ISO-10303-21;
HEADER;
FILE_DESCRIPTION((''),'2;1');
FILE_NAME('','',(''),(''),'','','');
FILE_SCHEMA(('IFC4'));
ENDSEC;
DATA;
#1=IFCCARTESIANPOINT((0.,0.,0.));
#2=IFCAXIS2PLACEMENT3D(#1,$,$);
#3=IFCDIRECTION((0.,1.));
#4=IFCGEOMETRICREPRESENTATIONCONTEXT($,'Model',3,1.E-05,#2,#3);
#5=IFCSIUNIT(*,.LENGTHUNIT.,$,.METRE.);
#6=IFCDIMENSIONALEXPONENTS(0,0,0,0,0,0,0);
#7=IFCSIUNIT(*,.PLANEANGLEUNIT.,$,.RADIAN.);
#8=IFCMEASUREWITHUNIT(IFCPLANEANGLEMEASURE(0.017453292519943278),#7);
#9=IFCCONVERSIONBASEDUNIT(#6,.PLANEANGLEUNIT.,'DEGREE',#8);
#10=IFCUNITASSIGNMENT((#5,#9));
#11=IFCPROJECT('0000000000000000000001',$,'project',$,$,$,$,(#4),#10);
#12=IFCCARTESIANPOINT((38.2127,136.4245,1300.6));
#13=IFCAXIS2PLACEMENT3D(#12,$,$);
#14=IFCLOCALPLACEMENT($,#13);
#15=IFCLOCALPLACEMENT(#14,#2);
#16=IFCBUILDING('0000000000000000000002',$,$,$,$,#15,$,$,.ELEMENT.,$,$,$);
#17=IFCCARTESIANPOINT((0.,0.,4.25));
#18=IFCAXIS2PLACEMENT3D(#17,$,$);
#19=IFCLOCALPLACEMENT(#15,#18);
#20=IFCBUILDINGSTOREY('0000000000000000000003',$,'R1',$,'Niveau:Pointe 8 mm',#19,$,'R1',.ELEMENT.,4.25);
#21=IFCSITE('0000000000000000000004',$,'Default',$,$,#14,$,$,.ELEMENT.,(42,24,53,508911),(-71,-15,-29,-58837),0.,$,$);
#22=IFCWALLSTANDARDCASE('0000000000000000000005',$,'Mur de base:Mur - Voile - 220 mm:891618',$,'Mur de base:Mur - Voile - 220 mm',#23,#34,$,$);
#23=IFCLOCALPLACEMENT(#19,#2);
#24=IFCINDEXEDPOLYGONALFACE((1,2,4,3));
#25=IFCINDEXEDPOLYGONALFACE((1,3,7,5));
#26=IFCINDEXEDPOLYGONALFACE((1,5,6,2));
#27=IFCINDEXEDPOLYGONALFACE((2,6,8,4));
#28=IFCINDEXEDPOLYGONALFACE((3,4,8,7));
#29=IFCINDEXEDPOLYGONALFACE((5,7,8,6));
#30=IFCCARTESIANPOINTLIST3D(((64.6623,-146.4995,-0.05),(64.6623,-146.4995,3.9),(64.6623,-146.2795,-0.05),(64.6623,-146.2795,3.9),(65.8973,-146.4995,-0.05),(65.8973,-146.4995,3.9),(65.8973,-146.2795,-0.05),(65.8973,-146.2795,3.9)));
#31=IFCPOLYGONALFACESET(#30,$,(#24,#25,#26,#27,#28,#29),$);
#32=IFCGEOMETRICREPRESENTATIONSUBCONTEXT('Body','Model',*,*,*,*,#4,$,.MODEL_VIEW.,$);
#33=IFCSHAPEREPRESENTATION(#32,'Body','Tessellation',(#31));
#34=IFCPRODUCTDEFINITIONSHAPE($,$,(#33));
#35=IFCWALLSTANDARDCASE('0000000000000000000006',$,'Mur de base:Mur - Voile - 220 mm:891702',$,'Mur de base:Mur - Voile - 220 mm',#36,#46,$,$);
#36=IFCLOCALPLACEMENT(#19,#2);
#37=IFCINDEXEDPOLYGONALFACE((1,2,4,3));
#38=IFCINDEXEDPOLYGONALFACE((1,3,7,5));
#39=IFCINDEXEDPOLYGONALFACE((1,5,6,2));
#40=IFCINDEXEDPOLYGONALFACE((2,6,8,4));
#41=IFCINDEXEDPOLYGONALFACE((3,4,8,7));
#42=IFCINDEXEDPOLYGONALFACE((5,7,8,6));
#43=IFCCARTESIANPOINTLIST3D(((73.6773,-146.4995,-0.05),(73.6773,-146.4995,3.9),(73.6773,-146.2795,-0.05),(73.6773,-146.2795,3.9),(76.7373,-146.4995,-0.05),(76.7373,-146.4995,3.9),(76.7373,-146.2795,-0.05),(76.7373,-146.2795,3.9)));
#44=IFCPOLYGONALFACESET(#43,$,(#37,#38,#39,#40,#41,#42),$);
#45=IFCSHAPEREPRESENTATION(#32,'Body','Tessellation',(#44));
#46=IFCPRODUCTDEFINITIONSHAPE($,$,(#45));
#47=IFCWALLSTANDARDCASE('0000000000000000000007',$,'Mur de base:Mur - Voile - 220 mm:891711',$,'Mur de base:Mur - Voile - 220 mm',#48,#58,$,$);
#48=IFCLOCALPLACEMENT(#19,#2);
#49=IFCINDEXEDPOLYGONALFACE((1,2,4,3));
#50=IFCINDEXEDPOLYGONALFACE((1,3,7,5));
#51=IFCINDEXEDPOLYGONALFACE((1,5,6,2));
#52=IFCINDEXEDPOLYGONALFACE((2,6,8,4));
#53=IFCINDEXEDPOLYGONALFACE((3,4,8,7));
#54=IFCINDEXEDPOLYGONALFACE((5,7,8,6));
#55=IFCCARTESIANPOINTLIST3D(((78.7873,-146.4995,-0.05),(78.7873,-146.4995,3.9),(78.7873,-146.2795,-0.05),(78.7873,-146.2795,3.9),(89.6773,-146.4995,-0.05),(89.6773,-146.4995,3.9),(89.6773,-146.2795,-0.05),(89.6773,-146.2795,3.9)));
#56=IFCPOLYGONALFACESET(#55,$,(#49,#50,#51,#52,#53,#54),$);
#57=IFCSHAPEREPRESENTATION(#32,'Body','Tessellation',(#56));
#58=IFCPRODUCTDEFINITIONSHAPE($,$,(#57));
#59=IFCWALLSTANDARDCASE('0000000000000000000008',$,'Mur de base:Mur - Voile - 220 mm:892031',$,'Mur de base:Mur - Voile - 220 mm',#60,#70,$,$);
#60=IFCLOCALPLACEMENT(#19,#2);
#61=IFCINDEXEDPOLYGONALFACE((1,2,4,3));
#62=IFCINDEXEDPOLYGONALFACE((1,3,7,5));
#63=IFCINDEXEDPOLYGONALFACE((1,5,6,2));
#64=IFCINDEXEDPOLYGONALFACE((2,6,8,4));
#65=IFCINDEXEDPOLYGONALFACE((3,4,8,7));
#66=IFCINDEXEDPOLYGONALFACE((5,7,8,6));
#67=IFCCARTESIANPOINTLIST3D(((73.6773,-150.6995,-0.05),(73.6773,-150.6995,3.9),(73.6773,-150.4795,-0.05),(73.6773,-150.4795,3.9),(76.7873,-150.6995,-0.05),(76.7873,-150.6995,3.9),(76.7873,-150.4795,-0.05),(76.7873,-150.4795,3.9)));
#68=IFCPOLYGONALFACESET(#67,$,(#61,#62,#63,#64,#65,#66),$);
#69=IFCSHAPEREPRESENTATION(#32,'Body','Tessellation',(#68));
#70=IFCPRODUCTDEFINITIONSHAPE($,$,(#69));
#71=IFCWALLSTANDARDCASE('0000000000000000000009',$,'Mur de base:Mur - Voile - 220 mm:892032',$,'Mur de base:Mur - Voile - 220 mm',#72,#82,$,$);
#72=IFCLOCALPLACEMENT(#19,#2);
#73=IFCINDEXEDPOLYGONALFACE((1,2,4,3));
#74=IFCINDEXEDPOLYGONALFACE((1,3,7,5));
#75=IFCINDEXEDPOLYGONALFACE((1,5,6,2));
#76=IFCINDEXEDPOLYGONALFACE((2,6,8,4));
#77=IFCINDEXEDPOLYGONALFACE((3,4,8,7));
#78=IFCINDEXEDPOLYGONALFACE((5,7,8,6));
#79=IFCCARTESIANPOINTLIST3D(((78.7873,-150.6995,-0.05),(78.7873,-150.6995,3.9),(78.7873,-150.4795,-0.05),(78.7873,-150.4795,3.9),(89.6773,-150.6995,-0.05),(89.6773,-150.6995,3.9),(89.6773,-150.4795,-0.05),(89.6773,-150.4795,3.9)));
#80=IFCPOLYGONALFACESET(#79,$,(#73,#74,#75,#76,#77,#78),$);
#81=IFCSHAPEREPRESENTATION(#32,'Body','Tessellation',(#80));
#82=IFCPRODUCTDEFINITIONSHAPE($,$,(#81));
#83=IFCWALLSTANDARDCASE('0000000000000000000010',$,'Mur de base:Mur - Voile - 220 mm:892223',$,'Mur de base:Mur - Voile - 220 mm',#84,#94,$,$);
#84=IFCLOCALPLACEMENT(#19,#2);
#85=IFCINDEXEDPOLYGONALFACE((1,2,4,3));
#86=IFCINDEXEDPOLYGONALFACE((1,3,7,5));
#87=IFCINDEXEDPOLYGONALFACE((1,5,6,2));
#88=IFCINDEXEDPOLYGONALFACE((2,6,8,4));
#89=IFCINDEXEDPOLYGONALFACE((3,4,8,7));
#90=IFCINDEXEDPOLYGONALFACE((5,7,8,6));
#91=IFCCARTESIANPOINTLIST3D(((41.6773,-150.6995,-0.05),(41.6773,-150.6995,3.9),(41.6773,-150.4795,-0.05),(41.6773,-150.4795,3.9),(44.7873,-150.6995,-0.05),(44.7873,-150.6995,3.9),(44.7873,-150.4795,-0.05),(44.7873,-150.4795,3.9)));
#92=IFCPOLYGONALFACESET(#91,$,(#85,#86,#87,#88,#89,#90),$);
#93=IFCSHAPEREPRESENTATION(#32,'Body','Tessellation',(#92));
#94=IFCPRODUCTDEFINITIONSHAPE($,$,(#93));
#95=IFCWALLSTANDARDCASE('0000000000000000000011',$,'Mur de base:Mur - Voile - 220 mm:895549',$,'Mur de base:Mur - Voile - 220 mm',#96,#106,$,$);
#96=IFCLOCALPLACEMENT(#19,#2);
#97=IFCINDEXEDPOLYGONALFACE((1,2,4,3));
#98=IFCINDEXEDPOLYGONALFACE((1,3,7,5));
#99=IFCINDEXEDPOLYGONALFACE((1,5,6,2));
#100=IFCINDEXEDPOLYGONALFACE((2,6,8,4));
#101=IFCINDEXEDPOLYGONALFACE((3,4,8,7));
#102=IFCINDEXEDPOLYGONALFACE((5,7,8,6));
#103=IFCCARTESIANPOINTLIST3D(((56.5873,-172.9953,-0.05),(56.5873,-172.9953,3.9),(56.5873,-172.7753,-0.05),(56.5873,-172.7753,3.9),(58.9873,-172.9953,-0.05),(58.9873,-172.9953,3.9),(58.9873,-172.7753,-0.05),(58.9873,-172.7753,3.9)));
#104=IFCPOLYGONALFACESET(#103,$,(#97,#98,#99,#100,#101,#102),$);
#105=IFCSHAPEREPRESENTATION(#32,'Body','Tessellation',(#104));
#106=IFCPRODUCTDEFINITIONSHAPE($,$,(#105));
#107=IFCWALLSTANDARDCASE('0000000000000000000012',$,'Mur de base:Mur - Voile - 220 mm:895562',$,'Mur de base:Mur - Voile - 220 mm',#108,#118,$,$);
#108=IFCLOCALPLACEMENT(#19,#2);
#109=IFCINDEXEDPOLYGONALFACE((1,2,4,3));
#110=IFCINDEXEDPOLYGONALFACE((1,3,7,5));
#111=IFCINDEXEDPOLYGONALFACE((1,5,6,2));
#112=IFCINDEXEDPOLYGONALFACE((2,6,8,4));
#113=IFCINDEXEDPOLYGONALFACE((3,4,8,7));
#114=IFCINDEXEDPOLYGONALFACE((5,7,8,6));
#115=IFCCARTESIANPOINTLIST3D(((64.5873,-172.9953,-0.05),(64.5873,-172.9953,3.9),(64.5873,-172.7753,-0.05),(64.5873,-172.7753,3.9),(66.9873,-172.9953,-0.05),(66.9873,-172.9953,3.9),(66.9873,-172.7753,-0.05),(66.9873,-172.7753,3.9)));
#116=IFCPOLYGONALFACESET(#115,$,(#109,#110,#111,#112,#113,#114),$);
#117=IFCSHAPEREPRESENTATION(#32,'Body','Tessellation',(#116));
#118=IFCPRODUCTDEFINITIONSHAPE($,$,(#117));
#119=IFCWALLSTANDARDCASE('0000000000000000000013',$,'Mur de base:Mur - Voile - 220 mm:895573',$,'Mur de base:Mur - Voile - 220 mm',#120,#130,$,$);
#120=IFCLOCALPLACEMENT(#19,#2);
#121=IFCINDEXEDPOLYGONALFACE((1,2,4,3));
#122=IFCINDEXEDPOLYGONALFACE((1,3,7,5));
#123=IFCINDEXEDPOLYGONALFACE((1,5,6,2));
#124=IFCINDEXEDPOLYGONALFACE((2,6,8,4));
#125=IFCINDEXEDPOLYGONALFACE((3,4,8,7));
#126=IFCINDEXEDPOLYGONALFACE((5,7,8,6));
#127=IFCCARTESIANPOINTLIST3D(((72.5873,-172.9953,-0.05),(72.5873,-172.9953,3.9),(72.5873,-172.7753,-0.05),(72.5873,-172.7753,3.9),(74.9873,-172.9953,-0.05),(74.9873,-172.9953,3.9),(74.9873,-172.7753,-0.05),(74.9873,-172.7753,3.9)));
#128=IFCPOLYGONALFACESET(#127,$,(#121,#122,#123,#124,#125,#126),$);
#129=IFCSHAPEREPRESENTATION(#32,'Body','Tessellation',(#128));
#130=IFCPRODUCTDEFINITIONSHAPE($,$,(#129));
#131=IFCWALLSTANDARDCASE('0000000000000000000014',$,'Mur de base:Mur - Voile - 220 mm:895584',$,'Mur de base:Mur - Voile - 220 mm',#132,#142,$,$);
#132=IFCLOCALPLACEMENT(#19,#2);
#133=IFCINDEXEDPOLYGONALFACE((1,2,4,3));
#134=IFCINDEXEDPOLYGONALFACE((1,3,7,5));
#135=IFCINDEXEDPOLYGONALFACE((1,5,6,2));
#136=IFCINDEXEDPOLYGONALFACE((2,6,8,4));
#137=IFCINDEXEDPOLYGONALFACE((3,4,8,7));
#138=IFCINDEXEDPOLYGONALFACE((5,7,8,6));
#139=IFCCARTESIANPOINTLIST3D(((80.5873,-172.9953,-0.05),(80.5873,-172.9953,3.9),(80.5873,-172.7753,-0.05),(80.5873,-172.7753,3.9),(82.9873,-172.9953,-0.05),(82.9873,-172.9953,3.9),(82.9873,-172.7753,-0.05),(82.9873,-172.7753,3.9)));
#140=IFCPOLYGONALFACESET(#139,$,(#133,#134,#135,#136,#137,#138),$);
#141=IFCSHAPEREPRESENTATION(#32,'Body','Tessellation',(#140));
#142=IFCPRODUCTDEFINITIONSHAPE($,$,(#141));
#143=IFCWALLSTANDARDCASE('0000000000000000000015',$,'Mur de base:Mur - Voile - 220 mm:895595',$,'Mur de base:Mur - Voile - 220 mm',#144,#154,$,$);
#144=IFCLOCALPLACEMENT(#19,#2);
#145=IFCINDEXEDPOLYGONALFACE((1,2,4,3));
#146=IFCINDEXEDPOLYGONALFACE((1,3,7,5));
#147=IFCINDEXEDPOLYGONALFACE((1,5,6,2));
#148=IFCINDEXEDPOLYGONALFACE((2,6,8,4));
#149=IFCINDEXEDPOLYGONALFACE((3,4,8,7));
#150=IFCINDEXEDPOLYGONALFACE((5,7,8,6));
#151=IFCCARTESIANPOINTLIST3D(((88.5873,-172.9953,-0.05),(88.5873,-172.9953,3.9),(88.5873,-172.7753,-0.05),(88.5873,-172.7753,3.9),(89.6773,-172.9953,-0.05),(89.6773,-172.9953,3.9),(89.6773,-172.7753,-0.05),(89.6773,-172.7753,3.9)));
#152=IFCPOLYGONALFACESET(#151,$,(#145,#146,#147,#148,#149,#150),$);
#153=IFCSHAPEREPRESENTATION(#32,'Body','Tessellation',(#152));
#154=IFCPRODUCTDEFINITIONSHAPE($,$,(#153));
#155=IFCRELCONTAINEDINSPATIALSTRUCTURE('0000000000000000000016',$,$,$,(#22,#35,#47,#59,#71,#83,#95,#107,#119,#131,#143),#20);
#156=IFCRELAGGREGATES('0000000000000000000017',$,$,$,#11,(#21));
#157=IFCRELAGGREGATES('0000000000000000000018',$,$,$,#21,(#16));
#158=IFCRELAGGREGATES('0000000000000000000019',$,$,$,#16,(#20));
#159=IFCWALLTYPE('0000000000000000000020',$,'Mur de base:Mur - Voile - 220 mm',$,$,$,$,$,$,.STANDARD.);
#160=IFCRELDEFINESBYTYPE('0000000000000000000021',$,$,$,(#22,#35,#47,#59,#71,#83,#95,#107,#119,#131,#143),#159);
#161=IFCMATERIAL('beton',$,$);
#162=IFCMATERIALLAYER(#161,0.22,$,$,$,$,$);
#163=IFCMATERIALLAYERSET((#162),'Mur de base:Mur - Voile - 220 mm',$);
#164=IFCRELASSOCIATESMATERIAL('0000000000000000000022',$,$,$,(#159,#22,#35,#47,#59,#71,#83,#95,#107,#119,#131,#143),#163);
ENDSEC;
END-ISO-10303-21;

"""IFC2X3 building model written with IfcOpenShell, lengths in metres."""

from ifc_helpers import new_model, entity, si_unit, converted_unit, direction, frame, frame_2d, origin, place, context, subcontext, project, spatial, polyline, rectangle, extrude, clip, bounded_halfspace, material, layer, layer_set, layer_usage, type_object, element, save


model = new_model("IFC2X3")

# Units and contexts
model_context = context("Model", 3, precision=1e-05, world=origin(), true_north=direction((0.0, 1.0)))
body_context = subcontext(model_context, "Body", "Model", "MODEL_VIEW")
ifc_project = project(units=[si_unit("LENGTHUNIT", "METRE"), converted_unit("PLANEANGLEUNIT", "DEGREE", entity("IfcPlaneAngleMeasure", 0.017453292519943278), si_unit("PLANEANGLEUNIT", "RADIAN"), dimensions=[0, 0, 0, 0, 0, 0, 0])], contexts=[model_context])

# Site, building, storey
site_placement = place(None, frame((38.2127, 136.4245, 1300.6)))
site = spatial("IfcSite", under=ifc_project, at=site_placement, Name="Default", CompositionType="ELEMENT", RefLatitude=(42, 24, 53, 508911), RefLongitude=(-71, -15, -29, -58837), RefElevation=0.0)
building_placement = place(site_placement, origin())
building = spatial("IfcBuilding", under=site, at=building_placement, CompositionType="ELEMENT")
storey_placement = place(building_placement, frame((0.0, 0.0, 4.25)))
storey = spatial("IfcBuildingStorey", under=building, at=storey_placement, Name="R1", ObjectType="Niveau:Pointe 8 mm", LongName="R1", CompositionType="ELEMENT", Elevation=4.25)

# Shared definitions
ifc_material = material(Name="beton")
ifc_layer = layer(ifc_material, 0.22)
ifc_layer_set = layer_set([ifc_layer], Name="Mur de base:Mur - Voile - 220 mm")
wall_type = type_object("IfcWallType", Name="Mur de base:Mur - Voile - 220 mm", PredefinedType="STANDARD", material=ifc_layer_set)

# Walls
ifc_layer_usage_1 = layer_usage(ifc_layer_set, "AXIS2", "NEGATIVE", 0.11)
wall_1_placement = place(storey_placement, frame((64.6623, -146.3895, -0.05)))
element("IfcWallStandardCase", 1, at=wall_1_placement, inside=storey, type_object=wall_type, material=ifc_layer_usage_1, Name="Mur de base:Mur - Voile - 220 mm:891618", ObjectType="Mur de base:Mur - Voile - 220 mm", context=body_context, shape_type="Clipping", body=[
    clip(extrude(rectangle(XDim=1.235, YDim=0.22, at=frame_2d((0.6175, 0.0), x_axis=(-1.0, 0.0))), origin(), (0.0, 0.0, 1.0), 3.95), bounded_halfspace(frame((0.0, -0.11, 3.95), z_axis=(0.0, 0.0, -1.0), x_axis=(1.0, 0.0, 0.0)), True, frame((0.0, -0.11, 3.95)), polyline([(0.0, 0.0), (1.235, 0.0), (1.235, 0.22), (1.015, 0.22), (0.0, 0.22), (0.0, 0.0)]))),
])
ifc_layer_usage_2 = layer_usage(ifc_layer_set, "AXIS2", "NEGATIVE", 0.11)
wall_2_placement = place(storey_placement, frame((73.6773, -146.3895, -0.05)))
element("IfcWallStandardCase", 2, at=wall_2_placement, inside=storey, type_object=wall_type, material=ifc_layer_usage_2, Name="Mur de base:Mur - Voile - 220 mm:891702", ObjectType="Mur de base:Mur - Voile - 220 mm", context=body_context, shape_type="Clipping", body=[
    clip(extrude(rectangle(XDim=3.06, YDim=0.22, at=frame_2d((1.53, 0.0), x_axis=(-1.0, 0.0))), origin(), (0.0, 0.0, 1.0), 3.95), bounded_halfspace(frame((0.0, -0.11, 3.95), z_axis=(0.0, 0.0, -1.0), x_axis=(1.0, 0.0, 0.0)), True, frame((0.0, -0.11, 3.95)), polyline([(0.0, 0.0), (3.06, 0.0), (3.06, 0.22), (0.22, 0.22), (0.0, 0.22), (0.0, 0.0)]))),
])
ifc_layer_usage_3 = layer_usage(ifc_layer_set, "AXIS2", "NEGATIVE", 0.11)
wall_3_placement = place(storey_placement, frame((78.7873, -146.3895, -0.05)))
element("IfcWallStandardCase", 3, at=wall_3_placement, inside=storey, type_object=wall_type, material=ifc_layer_usage_3, Name="Mur de base:Mur - Voile - 220 mm:891711", ObjectType="Mur de base:Mur - Voile - 220 mm", context=body_context, shape_type="Clipping", body=[
    clip(extrude(rectangle(XDim=10.89, YDim=0.22, at=frame_2d((5.445, 0.0), x_axis=(-1.0, 0.0))), origin(), (0.0, 0.0, 1.0), 3.95), bounded_halfspace(frame((0.0, -0.11, 3.95), z_axis=(0.0, 0.0, -1.0), x_axis=(1.0, 0.0, 0.0)), True, frame((0.0, -0.11, 3.95)), polyline([(0.0, 0.0), (8.28, 0.0), (8.5, 0.0), (10.89, 0.0), (10.89, 0.22), (0.0, 0.22), (0.0, 0.0)]))),
])
ifc_layer_usage_4 = layer_usage(ifc_layer_set, "AXIS2", "NEGATIVE", 0.11)
wall_4_placement = place(storey_placement, frame((73.6773, -150.5895, -0.05)))
element("IfcWallStandardCase", 4, at=wall_4_placement, inside=storey, type_object=wall_type, material=ifc_layer_usage_4, Name="Mur de base:Mur - Voile - 220 mm:892031", ObjectType="Mur de base:Mur - Voile - 220 mm", context=body_context, shape_type="Clipping", body=[
    clip(extrude(rectangle(XDim=3.11, YDim=0.22, at=frame_2d((1.555, 0.0), x_axis=(-1.0, 0.0))), origin(), (0.0, 0.0, 1.0), 3.95), bounded_halfspace(frame((0.0, -0.11, 3.95), z_axis=(0.0, 0.0, -1.0), x_axis=(1.0, 0.0, 0.0)), True, frame((0.0, -0.11, 3.95)), polyline([(0.0, 0.0), (0.22, 0.0), (3.11, 0.0), (3.11, 0.22), (0.0, 0.22), (0.0, 0.0)]))),
])
ifc_layer_usage_5 = layer_usage(ifc_layer_set, "AXIS2", "NEGATIVE", 0.11)
wall_5_placement = place(storey_placement, frame((78.7873, -150.5895, -0.05)))
element("IfcWallStandardCase", 5, at=wall_5_placement, inside=storey, type_object=wall_type, material=ifc_layer_usage_5, Name="Mur de base:Mur - Voile - 220 mm:892032", ObjectType="Mur de base:Mur - Voile - 220 mm", context=body_context, shape_type="Clipping", body=[
    clip(extrude(rectangle(XDim=10.89, YDim=0.22, at=frame_2d((5.445, 0.0), x_axis=(-1.0, 0.0))), origin(), (0.0, 0.0, 1.0), 3.95), bounded_halfspace(frame((0.0, -0.11, 3.95), z_axis=(0.0, 0.0, -1.0), x_axis=(1.0, 0.0, 0.0)), True, frame((0.0, -0.11, 3.95)), polyline([(0.0, 0.0), (10.89, 0.0), (10.89, 0.22), (0.0, 0.22), (0.0, 0.0)]))),
])
ifc_layer_usage_6 = layer_usage(ifc_layer_set, "AXIS2", "NEGATIVE", 0.11)
wall_6_placement = place(storey_placement, frame((41.6773, -150.5895, -0.05)))
element("IfcWallStandardCase", 6, at=wall_6_placement, inside=storey, type_object=wall_type, material=ifc_layer_usage_6, Name="Mur de base:Mur - Voile - 220 mm:892223", ObjectType="Mur de base:Mur - Voile - 220 mm", context=body_context, shape_type="Clipping", body=[
    clip(extrude(rectangle(XDim=3.11, YDim=0.22, at=frame_2d((1.555, 0.0), x_axis=(-1.0, 0.0))), origin(), (0.0, 0.0, 1.0), 3.95), bounded_halfspace(frame((0.0, -0.11, 3.95), z_axis=(0.0, 0.0, -1.0), x_axis=(1.0, 0.0, 0.0)), True, frame((0.0, -0.11, 3.95)), polyline([(0.0, 0.0), (0.22, 0.0), (3.11, 0.0), (3.11, 0.22), (0.0, 0.22), (0.0, 0.0)]))),
])
ifc_layer_usage_7 = layer_usage(ifc_layer_set, "AXIS2", "NEGATIVE", 0.11)
wall_7_placement = place(storey_placement, frame((56.5873, -172.8853, -0.05)))
element("IfcWallStandardCase", 7, at=wall_7_placement, inside=storey, type_object=wall_type, material=ifc_layer_usage_7, Name="Mur de base:Mur - Voile - 220 mm:895549", ObjectType="Mur de base:Mur - Voile - 220 mm", context=body_context, shape_type="Clipping", body=[
    clip(extrude(rectangle(XDim=2.4, YDim=0.22, at=frame_2d((1.2, 0.0), x_axis=(-1.0, 0.0))), origin(), (0.0, 0.0, 1.0), 3.95), bounded_halfspace(frame((0.0, -0.11, 3.95), z_axis=(0.0, 0.0, -1.0), x_axis=(1.0, 0.0, 0.0)), True, frame((0.0, -0.11, 3.95)), polyline([(0.0, 0.0), (1.09, 0.0), (1.31, 0.0), (2.4, 0.0), (2.4, 0.22), (1.31, 0.22), (1.09, 0.22), (0.0, 0.22), (0.0, 0.0)]))),
])
ifc_layer_usage_8 = layer_usage(ifc_layer_set, "AXIS2", "NEGATIVE", 0.11)
wall_8_placement = place(storey_placement, frame((64.5873, -172.8853, -0.05)))
element("IfcWallStandardCase", 8, at=wall_8_placement, inside=storey, type_object=wall_type, material=ifc_layer_usage_8, Name="Mur de base:Mur - Voile - 220 mm:895562", ObjectType="Mur de base:Mur - Voile - 220 mm", context=body_context, shape_type="Clipping", body=[
    clip(extrude(rectangle(XDim=2.4, YDim=0.22, at=frame_2d((1.2, 0.0), x_axis=(-1.0, 0.0))), origin(), (0.0, 0.0, 1.0), 3.95), bounded_halfspace(frame((0.0, -0.11, 3.95), z_axis=(0.0, 0.0, -1.0), x_axis=(1.0, 0.0, 0.0)), True, frame((0.0, -0.11, 3.95)), polyline([(0.0, 0.0), (1.09, 0.0), (1.31, 0.0), (2.4, 0.0), (2.4, 0.22), (1.31, 0.22), (1.09, 0.22), (0.0, 0.22), (0.0, 0.0)]))),
])
ifc_layer_usage_9 = layer_usage(ifc_layer_set, "AXIS2", "NEGATIVE", 0.11)
wall_9_placement = place(storey_placement, frame((72.5873, -172.8853, -0.05)))
element("IfcWallStandardCase", 9, at=wall_9_placement, inside=storey, type_object=wall_type, material=ifc_layer_usage_9, Name="Mur de base:Mur - Voile - 220 mm:895573", ObjectType="Mur de base:Mur - Voile - 220 mm", context=body_context, shape_type="Clipping", body=[
    clip(extrude(rectangle(XDim=2.4, YDim=0.22, at=frame_2d((1.2, 0.0), x_axis=(-1.0, 0.0))), origin(), (0.0, 0.0, 1.0), 3.95), bounded_halfspace(frame((0.0, -0.11, 3.95), z_axis=(0.0, 0.0, -1.0), x_axis=(1.0, 0.0, 0.0)), True, frame((0.0, -0.11, 3.95)), polyline([(0.0, 0.0), (1.09, 0.0), (1.31, 0.0), (2.4, 0.0), (2.4, 0.22), (1.31, 0.22), (1.09, 0.22), (0.0, 0.22), (0.0, 0.0)]))),
])
ifc_layer_usage_10 = layer_usage(ifc_layer_set, "AXIS2", "NEGATIVE", 0.11)
wall_10_placement = place(storey_placement, frame((80.5873, -172.8853, -0.05)))
element("IfcWallStandardCase", 10, at=wall_10_placement, inside=storey, type_object=wall_type, material=ifc_layer_usage_10, Name="Mur de base:Mur - Voile - 220 mm:895584", ObjectType="Mur de base:Mur - Voile - 220 mm", context=body_context, shape_type="Clipping", body=[
    clip(extrude(rectangle(XDim=2.4, YDim=0.22, at=frame_2d((1.2, 0.0), x_axis=(-1.0, 0.0))), origin(), (0.0, 0.0, 1.0), 3.95), bounded_halfspace(frame((0.0, -0.11, 3.95), z_axis=(0.0, 0.0, -1.0), x_axis=(1.0, 0.0, 0.0)), True, frame((0.0, -0.11, 3.95)), polyline([(0.0, 0.0), (1.09, 0.0), (1.31, 0.0), (2.4, 0.0), (2.4, 0.22), (1.31, 0.22), (1.09, 0.22), (0.0, 0.22), (0.0, 0.0)]))),
])
ifc_layer_usage_11 = layer_usage(ifc_layer_set, "AXIS2", "NEGATIVE", 0.11)
wall_11_placement = place(storey_placement, frame((88.5873, -172.8853, -0.05)))
element("IfcWallStandardCase", 11, at=wall_11_placement, inside=storey, type_object=wall_type, material=ifc_layer_usage_11, Name="Mur de base:Mur - Voile - 220 mm:895595", ObjectType="Mur de base:Mur - Voile - 220 mm", context=body_context, shape_type="Clipping", body=[
    clip(extrude(rectangle(XDim=1.09, YDim=0.22, at=frame_2d((0.545, 0.0), x_axis=(-1.0, 0.0))), origin(), (0.0, 0.0, 1.0), 3.95), bounded_halfspace(frame((0.0, -0.11, 3.95), z_axis=(0.0, 0.0, -1.0), x_axis=(1.0, 0.0, 0.0)), True, frame((0.0, -0.11, 3.95)), polyline([(0.0, 0.0), (1.09, 0.0), (1.09, 0.22), (0.0, 0.22), (0.0, 0.0)]))),
])

save(model, "model.ifc")
